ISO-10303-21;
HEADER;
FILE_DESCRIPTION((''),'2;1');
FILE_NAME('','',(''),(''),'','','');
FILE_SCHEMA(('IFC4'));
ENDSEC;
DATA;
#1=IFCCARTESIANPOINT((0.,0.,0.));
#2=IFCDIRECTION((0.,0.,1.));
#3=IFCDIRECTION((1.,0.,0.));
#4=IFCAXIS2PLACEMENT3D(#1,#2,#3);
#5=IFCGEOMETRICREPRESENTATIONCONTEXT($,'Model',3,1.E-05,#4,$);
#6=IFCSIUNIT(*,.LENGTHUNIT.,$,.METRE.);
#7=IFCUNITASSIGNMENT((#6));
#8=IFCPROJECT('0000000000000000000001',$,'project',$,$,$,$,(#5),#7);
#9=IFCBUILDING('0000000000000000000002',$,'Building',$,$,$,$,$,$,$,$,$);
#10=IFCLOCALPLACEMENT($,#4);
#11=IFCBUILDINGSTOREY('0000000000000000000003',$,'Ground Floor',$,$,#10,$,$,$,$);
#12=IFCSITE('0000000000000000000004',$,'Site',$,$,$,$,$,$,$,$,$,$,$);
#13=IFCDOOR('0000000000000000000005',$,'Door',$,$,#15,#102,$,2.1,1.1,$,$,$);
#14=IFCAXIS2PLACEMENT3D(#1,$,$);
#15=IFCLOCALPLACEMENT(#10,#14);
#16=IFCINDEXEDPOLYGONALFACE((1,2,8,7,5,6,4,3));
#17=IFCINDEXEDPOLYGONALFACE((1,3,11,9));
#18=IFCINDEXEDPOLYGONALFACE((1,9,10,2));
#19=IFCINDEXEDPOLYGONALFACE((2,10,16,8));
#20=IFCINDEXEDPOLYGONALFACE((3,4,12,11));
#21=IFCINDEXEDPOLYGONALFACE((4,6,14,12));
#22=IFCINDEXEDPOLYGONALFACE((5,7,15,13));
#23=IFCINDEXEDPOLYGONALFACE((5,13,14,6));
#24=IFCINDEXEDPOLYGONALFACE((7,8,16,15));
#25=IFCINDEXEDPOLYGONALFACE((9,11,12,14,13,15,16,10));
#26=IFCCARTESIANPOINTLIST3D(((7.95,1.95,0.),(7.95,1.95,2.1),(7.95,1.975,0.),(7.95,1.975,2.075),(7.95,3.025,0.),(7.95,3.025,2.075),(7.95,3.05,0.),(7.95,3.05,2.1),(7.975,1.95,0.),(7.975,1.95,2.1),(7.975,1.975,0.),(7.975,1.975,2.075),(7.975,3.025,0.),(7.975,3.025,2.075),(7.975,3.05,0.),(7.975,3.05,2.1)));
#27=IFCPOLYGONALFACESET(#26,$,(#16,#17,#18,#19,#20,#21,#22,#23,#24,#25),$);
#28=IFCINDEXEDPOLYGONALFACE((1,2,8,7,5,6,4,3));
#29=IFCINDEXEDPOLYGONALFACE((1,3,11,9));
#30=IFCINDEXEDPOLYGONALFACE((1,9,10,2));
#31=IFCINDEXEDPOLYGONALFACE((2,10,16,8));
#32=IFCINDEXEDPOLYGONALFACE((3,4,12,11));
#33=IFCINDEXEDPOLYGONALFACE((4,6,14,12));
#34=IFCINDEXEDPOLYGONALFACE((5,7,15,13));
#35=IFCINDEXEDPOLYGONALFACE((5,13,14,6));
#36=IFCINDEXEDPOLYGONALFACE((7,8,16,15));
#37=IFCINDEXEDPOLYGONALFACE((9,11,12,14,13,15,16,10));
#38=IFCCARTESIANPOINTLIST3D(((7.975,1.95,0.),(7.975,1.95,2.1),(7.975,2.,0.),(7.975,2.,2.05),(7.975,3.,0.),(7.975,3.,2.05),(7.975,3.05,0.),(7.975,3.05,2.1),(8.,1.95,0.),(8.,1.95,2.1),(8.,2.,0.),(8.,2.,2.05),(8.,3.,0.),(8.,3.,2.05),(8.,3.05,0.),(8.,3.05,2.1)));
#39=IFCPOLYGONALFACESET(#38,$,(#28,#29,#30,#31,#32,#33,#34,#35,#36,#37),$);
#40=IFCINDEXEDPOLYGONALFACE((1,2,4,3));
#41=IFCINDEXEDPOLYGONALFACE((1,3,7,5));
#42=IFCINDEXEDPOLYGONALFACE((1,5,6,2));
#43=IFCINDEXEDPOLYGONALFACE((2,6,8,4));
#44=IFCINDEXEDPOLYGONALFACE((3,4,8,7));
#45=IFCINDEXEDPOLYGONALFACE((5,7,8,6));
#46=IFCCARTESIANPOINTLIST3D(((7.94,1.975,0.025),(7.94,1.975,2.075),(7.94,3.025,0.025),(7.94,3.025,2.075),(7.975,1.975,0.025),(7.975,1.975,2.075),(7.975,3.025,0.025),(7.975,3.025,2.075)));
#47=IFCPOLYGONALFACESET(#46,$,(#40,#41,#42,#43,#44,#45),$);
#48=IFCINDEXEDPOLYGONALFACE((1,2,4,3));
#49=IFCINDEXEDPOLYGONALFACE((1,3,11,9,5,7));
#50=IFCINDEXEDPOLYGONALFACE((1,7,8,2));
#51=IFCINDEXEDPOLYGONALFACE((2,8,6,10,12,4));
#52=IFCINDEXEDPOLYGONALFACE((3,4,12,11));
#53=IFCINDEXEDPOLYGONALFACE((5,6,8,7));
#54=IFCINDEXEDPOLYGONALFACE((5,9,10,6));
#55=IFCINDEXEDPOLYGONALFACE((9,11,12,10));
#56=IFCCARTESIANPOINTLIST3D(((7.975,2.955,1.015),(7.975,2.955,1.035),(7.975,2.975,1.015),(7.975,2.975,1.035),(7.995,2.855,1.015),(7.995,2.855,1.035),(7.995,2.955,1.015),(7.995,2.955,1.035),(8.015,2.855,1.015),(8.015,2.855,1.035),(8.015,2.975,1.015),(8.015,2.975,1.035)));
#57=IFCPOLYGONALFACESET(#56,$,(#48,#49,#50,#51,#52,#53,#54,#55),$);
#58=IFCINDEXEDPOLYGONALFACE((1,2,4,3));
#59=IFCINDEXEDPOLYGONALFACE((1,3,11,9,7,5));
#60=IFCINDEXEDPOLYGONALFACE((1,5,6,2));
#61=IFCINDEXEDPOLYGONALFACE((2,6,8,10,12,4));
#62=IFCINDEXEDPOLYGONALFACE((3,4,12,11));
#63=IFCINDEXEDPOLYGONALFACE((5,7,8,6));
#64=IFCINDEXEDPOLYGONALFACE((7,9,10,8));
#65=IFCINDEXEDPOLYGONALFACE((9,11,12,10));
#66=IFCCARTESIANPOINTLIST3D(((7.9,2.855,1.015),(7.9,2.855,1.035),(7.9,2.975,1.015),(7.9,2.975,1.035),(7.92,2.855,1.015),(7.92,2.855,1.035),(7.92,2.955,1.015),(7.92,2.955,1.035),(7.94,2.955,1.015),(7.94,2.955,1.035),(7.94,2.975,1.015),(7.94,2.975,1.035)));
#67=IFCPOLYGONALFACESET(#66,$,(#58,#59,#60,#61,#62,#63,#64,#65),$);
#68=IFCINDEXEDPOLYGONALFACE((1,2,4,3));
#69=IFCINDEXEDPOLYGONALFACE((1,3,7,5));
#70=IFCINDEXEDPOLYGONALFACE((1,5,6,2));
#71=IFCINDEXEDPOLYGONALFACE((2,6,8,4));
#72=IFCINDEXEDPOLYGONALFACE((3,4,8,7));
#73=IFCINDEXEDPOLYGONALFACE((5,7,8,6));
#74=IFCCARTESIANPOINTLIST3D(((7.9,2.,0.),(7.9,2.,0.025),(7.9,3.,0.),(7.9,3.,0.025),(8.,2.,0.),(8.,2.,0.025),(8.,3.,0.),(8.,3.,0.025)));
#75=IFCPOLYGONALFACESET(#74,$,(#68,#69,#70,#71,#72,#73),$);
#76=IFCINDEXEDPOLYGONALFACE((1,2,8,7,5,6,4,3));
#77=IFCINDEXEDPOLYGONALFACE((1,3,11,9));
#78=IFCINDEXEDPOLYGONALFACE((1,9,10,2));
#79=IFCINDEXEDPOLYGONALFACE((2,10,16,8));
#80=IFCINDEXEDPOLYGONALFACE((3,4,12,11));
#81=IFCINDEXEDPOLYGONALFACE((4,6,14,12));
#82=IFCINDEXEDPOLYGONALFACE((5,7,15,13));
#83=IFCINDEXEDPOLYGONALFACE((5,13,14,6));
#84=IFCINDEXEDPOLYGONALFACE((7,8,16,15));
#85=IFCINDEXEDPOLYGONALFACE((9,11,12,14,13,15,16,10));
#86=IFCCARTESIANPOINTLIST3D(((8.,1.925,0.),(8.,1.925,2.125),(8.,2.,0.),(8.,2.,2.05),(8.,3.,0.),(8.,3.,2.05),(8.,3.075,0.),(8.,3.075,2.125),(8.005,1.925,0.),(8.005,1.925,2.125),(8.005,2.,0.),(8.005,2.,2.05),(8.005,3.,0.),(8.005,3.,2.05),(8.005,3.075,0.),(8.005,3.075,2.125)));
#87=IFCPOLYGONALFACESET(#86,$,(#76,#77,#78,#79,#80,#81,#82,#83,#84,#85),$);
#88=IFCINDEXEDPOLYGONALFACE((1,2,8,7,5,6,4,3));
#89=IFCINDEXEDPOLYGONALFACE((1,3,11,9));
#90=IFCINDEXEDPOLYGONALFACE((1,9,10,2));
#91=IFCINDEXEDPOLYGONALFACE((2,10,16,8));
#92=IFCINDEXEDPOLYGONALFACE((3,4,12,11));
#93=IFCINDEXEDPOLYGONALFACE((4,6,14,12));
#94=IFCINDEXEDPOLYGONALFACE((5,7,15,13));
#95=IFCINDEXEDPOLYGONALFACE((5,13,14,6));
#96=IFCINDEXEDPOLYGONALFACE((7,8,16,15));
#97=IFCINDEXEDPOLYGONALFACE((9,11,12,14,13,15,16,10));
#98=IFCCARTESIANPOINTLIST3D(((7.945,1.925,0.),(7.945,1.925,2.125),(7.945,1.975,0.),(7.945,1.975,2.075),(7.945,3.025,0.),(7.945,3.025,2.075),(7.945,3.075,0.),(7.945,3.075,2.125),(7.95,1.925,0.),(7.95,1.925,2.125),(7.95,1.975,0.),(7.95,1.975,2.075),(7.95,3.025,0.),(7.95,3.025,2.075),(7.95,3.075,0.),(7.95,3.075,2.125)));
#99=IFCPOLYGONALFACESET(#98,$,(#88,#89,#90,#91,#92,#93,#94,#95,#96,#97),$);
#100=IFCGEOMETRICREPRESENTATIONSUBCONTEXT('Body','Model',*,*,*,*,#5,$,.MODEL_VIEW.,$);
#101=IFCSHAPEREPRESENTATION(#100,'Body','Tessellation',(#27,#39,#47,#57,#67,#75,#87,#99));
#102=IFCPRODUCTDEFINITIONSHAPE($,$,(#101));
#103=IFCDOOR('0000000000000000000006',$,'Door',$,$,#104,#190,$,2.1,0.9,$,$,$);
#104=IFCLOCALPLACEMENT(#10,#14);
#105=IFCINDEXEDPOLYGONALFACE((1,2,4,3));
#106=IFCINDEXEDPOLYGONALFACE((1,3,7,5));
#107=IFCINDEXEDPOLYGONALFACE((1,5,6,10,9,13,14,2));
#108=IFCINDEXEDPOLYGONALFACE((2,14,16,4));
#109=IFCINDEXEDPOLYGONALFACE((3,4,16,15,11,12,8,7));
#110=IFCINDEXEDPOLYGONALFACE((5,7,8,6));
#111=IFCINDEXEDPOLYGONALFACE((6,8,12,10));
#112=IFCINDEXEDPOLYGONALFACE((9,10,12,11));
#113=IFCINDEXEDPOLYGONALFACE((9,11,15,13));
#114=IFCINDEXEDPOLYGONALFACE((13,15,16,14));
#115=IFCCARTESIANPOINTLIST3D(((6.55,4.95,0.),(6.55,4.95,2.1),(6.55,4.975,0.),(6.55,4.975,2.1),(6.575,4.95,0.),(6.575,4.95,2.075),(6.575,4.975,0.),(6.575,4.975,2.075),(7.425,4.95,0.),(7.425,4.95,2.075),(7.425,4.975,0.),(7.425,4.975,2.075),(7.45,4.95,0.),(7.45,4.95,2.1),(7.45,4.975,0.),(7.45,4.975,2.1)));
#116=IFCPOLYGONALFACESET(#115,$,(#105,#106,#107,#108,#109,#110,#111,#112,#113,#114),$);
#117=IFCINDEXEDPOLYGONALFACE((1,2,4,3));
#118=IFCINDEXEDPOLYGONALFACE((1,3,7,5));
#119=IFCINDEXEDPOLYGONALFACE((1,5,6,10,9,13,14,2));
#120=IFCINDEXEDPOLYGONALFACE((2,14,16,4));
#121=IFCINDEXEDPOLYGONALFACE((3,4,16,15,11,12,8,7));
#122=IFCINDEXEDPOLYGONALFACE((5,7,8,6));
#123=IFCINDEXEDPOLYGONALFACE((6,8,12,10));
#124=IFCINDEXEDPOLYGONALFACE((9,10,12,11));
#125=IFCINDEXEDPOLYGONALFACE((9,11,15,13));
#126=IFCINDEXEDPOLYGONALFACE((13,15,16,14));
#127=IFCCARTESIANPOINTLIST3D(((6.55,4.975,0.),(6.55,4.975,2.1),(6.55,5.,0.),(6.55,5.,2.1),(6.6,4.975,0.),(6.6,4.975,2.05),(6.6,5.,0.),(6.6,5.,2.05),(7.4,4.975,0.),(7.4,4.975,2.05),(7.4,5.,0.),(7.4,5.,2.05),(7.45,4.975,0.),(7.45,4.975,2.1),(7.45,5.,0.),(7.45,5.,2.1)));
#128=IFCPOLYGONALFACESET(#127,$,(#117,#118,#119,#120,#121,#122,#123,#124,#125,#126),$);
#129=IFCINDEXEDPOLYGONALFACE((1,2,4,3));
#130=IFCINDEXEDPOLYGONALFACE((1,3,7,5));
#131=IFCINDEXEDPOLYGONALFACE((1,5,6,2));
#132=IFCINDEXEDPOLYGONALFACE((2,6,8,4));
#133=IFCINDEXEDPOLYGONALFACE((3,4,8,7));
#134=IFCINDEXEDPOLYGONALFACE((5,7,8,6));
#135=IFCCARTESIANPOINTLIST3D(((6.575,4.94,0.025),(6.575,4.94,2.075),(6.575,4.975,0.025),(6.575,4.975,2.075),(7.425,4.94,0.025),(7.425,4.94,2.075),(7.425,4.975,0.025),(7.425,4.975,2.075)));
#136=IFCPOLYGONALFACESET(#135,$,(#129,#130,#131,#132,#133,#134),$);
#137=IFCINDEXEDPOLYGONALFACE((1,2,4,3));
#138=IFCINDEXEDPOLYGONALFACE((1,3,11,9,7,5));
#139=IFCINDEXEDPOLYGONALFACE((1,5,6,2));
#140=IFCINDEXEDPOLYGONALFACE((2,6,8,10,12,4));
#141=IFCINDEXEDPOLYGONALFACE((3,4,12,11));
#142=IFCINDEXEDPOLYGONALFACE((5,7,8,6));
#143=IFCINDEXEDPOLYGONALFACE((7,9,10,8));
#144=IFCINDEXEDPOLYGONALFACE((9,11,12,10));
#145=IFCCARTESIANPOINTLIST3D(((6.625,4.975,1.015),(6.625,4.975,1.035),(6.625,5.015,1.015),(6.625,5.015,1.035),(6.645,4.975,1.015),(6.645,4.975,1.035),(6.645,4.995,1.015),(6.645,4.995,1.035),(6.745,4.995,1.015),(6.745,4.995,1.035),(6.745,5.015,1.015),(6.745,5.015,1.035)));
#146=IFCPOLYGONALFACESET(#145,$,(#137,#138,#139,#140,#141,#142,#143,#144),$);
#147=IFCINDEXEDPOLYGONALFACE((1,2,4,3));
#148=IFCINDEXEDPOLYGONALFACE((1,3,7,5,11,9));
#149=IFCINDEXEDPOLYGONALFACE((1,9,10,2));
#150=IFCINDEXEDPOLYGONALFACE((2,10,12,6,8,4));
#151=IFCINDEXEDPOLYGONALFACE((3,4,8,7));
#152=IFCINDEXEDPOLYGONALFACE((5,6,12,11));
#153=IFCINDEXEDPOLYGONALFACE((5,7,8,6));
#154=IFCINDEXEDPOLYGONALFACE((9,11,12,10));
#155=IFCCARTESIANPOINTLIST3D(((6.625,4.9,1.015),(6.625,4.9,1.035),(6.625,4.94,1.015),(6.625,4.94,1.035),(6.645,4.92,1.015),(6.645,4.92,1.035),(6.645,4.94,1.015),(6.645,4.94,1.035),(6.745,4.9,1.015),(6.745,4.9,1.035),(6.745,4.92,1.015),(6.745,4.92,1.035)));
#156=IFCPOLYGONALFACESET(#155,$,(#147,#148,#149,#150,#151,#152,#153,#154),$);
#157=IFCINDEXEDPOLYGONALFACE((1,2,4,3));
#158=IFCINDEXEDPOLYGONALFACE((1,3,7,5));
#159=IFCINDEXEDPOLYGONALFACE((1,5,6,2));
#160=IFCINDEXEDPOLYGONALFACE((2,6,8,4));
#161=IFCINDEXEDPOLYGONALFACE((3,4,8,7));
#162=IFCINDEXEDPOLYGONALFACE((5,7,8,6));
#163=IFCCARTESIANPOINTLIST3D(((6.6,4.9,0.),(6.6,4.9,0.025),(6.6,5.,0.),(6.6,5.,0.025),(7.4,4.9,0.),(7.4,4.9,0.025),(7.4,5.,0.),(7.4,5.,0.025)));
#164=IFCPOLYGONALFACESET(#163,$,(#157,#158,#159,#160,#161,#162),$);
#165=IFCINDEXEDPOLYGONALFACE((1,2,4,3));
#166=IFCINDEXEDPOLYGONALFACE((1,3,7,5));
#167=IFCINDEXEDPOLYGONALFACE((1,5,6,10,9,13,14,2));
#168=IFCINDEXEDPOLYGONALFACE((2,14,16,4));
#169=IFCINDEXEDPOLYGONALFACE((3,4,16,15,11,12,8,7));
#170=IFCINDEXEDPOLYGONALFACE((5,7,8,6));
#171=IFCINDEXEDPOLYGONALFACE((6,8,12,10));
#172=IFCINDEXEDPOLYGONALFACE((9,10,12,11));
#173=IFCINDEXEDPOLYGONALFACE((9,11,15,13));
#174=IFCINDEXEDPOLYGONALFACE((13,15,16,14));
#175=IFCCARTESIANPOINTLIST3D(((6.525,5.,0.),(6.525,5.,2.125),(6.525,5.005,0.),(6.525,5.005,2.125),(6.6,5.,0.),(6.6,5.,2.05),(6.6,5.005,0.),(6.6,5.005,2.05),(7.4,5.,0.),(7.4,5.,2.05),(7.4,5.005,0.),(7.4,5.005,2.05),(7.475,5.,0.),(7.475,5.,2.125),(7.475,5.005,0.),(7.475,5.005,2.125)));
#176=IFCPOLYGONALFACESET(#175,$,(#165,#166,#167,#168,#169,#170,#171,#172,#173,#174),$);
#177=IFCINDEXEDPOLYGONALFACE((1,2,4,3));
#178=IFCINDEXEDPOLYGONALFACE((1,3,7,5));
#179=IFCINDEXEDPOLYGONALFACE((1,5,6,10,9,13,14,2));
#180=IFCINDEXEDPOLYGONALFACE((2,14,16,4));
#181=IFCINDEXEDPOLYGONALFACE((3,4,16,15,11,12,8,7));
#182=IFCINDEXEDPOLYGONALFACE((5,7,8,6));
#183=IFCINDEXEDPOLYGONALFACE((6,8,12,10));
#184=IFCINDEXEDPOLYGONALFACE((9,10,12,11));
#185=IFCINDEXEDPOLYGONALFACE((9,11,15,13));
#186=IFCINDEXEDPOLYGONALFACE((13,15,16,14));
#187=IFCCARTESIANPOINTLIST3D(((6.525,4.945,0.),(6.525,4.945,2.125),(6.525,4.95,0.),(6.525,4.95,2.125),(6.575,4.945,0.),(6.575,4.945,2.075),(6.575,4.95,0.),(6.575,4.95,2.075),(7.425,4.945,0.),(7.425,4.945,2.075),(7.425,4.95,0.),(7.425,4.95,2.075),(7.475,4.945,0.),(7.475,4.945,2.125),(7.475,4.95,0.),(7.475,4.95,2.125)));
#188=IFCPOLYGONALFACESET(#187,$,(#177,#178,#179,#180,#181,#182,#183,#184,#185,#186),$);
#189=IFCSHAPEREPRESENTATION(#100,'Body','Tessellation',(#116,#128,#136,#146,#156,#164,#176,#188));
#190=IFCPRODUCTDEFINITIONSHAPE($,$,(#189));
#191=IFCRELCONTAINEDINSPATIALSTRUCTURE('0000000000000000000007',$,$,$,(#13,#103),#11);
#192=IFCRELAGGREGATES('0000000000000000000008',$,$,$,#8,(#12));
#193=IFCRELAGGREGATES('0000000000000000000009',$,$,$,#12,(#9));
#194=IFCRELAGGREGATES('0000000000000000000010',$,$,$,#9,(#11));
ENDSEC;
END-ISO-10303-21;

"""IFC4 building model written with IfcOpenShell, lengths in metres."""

from ifc_helpers import new_model, si_unit, frame, origin_with_axes, place, context, subcontext, project, spatial, line, indexed_curve, outline, extrude, element, save


model = new_model("IFC4")

# Units and contexts
model_context = context("Model", 3, precision=1e-05, world=origin_with_axes())
body_context = subcontext(model_context, "Body", "Model", "MODEL_VIEW")
ifc_project = project(units=[si_unit("LENGTHUNIT", "METRE")], contexts=[model_context])

# Site, building, storey
site = spatial("IfcSite", under=ifc_project, Name="Site")
building = spatial("IfcBuilding", under=site, Name="Building")
storey_placement = place(None, origin_with_axes())
storey = spatial("IfcBuildingStorey", under=building, at=storey_placement, Name="Ground Floor")

# Doors
door_1_placement = place(storey_placement, frame((8.0, 1.95, 0.0), z_axis=(0.0, 0.0, 1.0), x_axis=(0.0, 1.0, 0.0)))
element("IfcDoor", 1, at=door_1_placement, inside=storey, Name="Door", OverallHeight=2.1, OverallWidth=1.1, context=body_context, shape_type="SweptSolid", body=[
    extrude(outline(indexed_curve([(0.0, 0.0), (0.0, 2.1), (1.1, 2.1), (1.1, 0.0), (1.075, 0.0), (1.075, 2.075), (0.025, 2.075), (0.025, 0.0)], segments=[line(1, 2, 3, 4, 5, 6, 7, 8, 1)])), frame((0.0, 0.025, 0.0), z_axis=(0.0, -1.0, 0.0), x_axis=(1.0, 0.0, 0.0)), (0.0, 0.0, -1.0), 0.025),
    extrude(outline(indexed_curve([(0.0, 0.0), (0.0, 2.1), (1.1, 2.1), (1.1, 0.0), (1.05, 0.0), (1.05, 2.05), (0.05, 2.05), (0.05, 0.0)], segments=[line(1, 2, 3, 4, 5, 6, 7, 8, 1)])), frame((0.0, 0.0, 0.0), z_axis=(0.0, -1.0, 0.0), x_axis=(1.0, 0.0, 0.0)), (0.0, 0.0, -1.0), 0.025),
    extrude(outline(indexed_curve([(0.0, 0.0), (1.05, 0.0), (1.05, 0.035), (0.0, 0.035)], segments=[line(1, 2, 3, 4, 1)])), frame((0.025, 0.025, 0.025), z_axis=(0.0, 0.0, 1.0), x_axis=(1.0, 0.0, 0.0)), (0.0, 0.0, 1.0), 2.05),
    extrude(outline(indexed_curve([(0.0, 0.0), (0.0, -0.04), (-0.12, -0.04), (-0.12, -0.02), (-0.02, -0.02), (-0.02, 0.0)], segments=[line(1, 2, 3, 4, 5, 6, 1)])), frame((1.025, 0.025, 1.015), z_axis=(0.0, 0.0, 1.0), x_axis=(1.0, 0.0, 0.0)), (0.0, 0.0, 1.0), 0.02),
    extrude(outline(indexed_curve([(0.0, 0.0), (0.0, 0.04), (-0.12, 0.04), (-0.12, 0.02), (-0.02, 0.02), (-0.02, 0.0)], segments=[line(1, 2, 3, 4, 5, 6, 1)])), frame((1.025, 0.06, 1.015), z_axis=(0.0, 0.0, 1.0), x_axis=(1.0, 0.0, 0.0)), (0.0, 0.0, 1.0), 0.02),
    extrude(outline(indexed_curve([(0.0, 0.0), (1.0, 0.0), (1.0, 0.1), (0.0, 0.1)], segments=[line(1, 2, 3, 4, 1)])), frame((0.05, 0.0, 0.0), z_axis=(0.0, 0.0, 1.0), x_axis=(1.0, 0.0, 0.0)), (0.0, 0.0, 1.0), 0.025),
    extrude(outline(indexed_curve([(0.0, 0.0), (0.0, 2.125), (1.15, 2.125), (1.15, 0.0), (1.075, 0.0), (1.075, 2.05), (0.075, 2.05), (0.075, 0.0)], segments=[line(1, 2, 3, 4, 5, 6, 7, 8, 1)])), frame((-0.025, -0.005, 0.0), z_axis=(0.0, -1.0, 0.0), x_axis=(1.0, 0.0, 0.0)), (0.0, 0.0, -1.0), 0.005),
    extrude(outline(indexed_curve([(0.0, 0.0), (0.0, 2.125), (1.15, 2.125), (1.15, 0.0), (1.1, 0.0), (1.1, 2.075), (0.05, 2.075), (0.05, 0.0)], segments=[line(1, 2, 3, 4, 5, 6, 7, 8, 1)])), frame((-0.025, 0.05, 0.0), z_axis=(0.0, -1.0, 0.0), x_axis=(1.0, 0.0, 0.0)), (0.0, 0.0, -1.0), 0.005),
])
door_2_placement = place(storey_placement, frame((7.45, 5.0, 0.0), z_axis=(0.0, 0.0, 1.0), x_axis=(-1.0, 0.0, 0.0)))
element("IfcDoor", 2, at=door_2_placement, inside=storey, Name="Door", OverallHeight=2.1, OverallWidth=0.9, context=body_context, shape_type="SweptSolid", body=[
    extrude(outline(indexed_curve([(0.0, 0.0), (0.0, 2.1), (0.9, 2.1), (0.9, 0.0), (0.875, 0.0), (0.875, 2.075), (0.025, 2.075), (0.025, 0.0)], segments=[line(1, 2, 3, 4, 5, 6, 7, 8, 1)])), frame((0.0, 0.025, 0.0), z_axis=(0.0, -1.0, 0.0), x_axis=(1.0, 0.0, 0.0)), (0.0, 0.0, -1.0), 0.025),
    extrude(outline(indexed_curve([(0.0, 0.0), (0.0, 2.1), (0.9, 2.1), (0.9, 0.0), (0.85, 0.0), (0.85, 2.05), (0.05, 2.05), (0.05, 0.0)], segments=[line(1, 2, 3, 4, 5, 6, 7, 8, 1)])), frame((0.0, 0.0, 0.0), z_axis=(0.0, -1.0, 0.0), x_axis=(1.0, 0.0, 0.0)), (0.0, 0.0, -1.0), 0.025),
    extrude(outline(indexed_curve([(0.0, 0.0), (0.85, 0.0), (0.85, 0.035), (0.0, 0.035)], segments=[line(1, 2, 3, 4, 1)])), frame((0.025, 0.025, 0.025), z_axis=(0.0, 0.0, 1.0), x_axis=(1.0, 0.0, 0.0)), (0.0, 0.0, 1.0), 2.05),
    extrude(outline(indexed_curve([(0.0, 0.0), (0.0, -0.04), (-0.12, -0.04), (-0.12, -0.02), (-0.02, -0.02), (-0.02, 0.0)], segments=[line(1, 2, 3, 4, 5, 6, 1)])), frame((0.825, 0.025, 1.015), z_axis=(0.0, 0.0, 1.0), x_axis=(1.0, 0.0, 0.0)), (0.0, 0.0, 1.0), 0.02),
    extrude(outline(indexed_curve([(0.0, 0.0), (0.0, 0.04), (-0.12, 0.04), (-0.12, 0.02), (-0.02, 0.02), (-0.02, 0.0)], segments=[line(1, 2, 3, 4, 5, 6, 1)])), frame((0.825, 0.06, 1.015), z_axis=(0.0, 0.0, 1.0), x_axis=(1.0, 0.0, 0.0)), (0.0, 0.0, 1.0), 0.02),
    extrude(outline(indexed_curve([(0.0, 0.0), (0.8, 0.0), (0.8, 0.1), (0.0, 0.1)], segments=[line(1, 2, 3, 4, 1)])), frame((0.05, 0.0, 0.0), z_axis=(0.0, 0.0, 1.0), x_axis=(1.0, 0.0, 0.0)), (0.0, 0.0, 1.0), 0.025),
    extrude(outline(indexed_curve([(0.0, 0.0), (0.0, 2.125), (0.95, 2.125), (0.95, 0.0), (0.875, 0.0), (0.875, 2.05), (0.075, 2.05), (0.075, 0.0)], segments=[line(1, 2, 3, 4, 5, 6, 7, 8, 1)])), frame((-0.025, -0.005, 0.0), z_axis=(0.0, -1.0, 0.0), x_axis=(1.0, 0.0, 0.0)), (0.0, 0.0, -1.0), 0.005),
    extrude(outline(indexed_curve([(0.0, 0.0), (0.0, 2.125), (0.95, 2.125), (0.95, 0.0), (0.9, 0.0), (0.9, 2.075), (0.05, 2.075), (0.05, 0.0)], segments=[line(1, 2, 3, 4, 5, 6, 7, 8, 1)])), frame((-0.025, 0.05, 0.0), z_axis=(0.0, -1.0, 0.0), x_axis=(1.0, 0.0, 0.0)), (0.0, 0.0, -1.0), 0.005),
])

save(model, "model.ifc")
